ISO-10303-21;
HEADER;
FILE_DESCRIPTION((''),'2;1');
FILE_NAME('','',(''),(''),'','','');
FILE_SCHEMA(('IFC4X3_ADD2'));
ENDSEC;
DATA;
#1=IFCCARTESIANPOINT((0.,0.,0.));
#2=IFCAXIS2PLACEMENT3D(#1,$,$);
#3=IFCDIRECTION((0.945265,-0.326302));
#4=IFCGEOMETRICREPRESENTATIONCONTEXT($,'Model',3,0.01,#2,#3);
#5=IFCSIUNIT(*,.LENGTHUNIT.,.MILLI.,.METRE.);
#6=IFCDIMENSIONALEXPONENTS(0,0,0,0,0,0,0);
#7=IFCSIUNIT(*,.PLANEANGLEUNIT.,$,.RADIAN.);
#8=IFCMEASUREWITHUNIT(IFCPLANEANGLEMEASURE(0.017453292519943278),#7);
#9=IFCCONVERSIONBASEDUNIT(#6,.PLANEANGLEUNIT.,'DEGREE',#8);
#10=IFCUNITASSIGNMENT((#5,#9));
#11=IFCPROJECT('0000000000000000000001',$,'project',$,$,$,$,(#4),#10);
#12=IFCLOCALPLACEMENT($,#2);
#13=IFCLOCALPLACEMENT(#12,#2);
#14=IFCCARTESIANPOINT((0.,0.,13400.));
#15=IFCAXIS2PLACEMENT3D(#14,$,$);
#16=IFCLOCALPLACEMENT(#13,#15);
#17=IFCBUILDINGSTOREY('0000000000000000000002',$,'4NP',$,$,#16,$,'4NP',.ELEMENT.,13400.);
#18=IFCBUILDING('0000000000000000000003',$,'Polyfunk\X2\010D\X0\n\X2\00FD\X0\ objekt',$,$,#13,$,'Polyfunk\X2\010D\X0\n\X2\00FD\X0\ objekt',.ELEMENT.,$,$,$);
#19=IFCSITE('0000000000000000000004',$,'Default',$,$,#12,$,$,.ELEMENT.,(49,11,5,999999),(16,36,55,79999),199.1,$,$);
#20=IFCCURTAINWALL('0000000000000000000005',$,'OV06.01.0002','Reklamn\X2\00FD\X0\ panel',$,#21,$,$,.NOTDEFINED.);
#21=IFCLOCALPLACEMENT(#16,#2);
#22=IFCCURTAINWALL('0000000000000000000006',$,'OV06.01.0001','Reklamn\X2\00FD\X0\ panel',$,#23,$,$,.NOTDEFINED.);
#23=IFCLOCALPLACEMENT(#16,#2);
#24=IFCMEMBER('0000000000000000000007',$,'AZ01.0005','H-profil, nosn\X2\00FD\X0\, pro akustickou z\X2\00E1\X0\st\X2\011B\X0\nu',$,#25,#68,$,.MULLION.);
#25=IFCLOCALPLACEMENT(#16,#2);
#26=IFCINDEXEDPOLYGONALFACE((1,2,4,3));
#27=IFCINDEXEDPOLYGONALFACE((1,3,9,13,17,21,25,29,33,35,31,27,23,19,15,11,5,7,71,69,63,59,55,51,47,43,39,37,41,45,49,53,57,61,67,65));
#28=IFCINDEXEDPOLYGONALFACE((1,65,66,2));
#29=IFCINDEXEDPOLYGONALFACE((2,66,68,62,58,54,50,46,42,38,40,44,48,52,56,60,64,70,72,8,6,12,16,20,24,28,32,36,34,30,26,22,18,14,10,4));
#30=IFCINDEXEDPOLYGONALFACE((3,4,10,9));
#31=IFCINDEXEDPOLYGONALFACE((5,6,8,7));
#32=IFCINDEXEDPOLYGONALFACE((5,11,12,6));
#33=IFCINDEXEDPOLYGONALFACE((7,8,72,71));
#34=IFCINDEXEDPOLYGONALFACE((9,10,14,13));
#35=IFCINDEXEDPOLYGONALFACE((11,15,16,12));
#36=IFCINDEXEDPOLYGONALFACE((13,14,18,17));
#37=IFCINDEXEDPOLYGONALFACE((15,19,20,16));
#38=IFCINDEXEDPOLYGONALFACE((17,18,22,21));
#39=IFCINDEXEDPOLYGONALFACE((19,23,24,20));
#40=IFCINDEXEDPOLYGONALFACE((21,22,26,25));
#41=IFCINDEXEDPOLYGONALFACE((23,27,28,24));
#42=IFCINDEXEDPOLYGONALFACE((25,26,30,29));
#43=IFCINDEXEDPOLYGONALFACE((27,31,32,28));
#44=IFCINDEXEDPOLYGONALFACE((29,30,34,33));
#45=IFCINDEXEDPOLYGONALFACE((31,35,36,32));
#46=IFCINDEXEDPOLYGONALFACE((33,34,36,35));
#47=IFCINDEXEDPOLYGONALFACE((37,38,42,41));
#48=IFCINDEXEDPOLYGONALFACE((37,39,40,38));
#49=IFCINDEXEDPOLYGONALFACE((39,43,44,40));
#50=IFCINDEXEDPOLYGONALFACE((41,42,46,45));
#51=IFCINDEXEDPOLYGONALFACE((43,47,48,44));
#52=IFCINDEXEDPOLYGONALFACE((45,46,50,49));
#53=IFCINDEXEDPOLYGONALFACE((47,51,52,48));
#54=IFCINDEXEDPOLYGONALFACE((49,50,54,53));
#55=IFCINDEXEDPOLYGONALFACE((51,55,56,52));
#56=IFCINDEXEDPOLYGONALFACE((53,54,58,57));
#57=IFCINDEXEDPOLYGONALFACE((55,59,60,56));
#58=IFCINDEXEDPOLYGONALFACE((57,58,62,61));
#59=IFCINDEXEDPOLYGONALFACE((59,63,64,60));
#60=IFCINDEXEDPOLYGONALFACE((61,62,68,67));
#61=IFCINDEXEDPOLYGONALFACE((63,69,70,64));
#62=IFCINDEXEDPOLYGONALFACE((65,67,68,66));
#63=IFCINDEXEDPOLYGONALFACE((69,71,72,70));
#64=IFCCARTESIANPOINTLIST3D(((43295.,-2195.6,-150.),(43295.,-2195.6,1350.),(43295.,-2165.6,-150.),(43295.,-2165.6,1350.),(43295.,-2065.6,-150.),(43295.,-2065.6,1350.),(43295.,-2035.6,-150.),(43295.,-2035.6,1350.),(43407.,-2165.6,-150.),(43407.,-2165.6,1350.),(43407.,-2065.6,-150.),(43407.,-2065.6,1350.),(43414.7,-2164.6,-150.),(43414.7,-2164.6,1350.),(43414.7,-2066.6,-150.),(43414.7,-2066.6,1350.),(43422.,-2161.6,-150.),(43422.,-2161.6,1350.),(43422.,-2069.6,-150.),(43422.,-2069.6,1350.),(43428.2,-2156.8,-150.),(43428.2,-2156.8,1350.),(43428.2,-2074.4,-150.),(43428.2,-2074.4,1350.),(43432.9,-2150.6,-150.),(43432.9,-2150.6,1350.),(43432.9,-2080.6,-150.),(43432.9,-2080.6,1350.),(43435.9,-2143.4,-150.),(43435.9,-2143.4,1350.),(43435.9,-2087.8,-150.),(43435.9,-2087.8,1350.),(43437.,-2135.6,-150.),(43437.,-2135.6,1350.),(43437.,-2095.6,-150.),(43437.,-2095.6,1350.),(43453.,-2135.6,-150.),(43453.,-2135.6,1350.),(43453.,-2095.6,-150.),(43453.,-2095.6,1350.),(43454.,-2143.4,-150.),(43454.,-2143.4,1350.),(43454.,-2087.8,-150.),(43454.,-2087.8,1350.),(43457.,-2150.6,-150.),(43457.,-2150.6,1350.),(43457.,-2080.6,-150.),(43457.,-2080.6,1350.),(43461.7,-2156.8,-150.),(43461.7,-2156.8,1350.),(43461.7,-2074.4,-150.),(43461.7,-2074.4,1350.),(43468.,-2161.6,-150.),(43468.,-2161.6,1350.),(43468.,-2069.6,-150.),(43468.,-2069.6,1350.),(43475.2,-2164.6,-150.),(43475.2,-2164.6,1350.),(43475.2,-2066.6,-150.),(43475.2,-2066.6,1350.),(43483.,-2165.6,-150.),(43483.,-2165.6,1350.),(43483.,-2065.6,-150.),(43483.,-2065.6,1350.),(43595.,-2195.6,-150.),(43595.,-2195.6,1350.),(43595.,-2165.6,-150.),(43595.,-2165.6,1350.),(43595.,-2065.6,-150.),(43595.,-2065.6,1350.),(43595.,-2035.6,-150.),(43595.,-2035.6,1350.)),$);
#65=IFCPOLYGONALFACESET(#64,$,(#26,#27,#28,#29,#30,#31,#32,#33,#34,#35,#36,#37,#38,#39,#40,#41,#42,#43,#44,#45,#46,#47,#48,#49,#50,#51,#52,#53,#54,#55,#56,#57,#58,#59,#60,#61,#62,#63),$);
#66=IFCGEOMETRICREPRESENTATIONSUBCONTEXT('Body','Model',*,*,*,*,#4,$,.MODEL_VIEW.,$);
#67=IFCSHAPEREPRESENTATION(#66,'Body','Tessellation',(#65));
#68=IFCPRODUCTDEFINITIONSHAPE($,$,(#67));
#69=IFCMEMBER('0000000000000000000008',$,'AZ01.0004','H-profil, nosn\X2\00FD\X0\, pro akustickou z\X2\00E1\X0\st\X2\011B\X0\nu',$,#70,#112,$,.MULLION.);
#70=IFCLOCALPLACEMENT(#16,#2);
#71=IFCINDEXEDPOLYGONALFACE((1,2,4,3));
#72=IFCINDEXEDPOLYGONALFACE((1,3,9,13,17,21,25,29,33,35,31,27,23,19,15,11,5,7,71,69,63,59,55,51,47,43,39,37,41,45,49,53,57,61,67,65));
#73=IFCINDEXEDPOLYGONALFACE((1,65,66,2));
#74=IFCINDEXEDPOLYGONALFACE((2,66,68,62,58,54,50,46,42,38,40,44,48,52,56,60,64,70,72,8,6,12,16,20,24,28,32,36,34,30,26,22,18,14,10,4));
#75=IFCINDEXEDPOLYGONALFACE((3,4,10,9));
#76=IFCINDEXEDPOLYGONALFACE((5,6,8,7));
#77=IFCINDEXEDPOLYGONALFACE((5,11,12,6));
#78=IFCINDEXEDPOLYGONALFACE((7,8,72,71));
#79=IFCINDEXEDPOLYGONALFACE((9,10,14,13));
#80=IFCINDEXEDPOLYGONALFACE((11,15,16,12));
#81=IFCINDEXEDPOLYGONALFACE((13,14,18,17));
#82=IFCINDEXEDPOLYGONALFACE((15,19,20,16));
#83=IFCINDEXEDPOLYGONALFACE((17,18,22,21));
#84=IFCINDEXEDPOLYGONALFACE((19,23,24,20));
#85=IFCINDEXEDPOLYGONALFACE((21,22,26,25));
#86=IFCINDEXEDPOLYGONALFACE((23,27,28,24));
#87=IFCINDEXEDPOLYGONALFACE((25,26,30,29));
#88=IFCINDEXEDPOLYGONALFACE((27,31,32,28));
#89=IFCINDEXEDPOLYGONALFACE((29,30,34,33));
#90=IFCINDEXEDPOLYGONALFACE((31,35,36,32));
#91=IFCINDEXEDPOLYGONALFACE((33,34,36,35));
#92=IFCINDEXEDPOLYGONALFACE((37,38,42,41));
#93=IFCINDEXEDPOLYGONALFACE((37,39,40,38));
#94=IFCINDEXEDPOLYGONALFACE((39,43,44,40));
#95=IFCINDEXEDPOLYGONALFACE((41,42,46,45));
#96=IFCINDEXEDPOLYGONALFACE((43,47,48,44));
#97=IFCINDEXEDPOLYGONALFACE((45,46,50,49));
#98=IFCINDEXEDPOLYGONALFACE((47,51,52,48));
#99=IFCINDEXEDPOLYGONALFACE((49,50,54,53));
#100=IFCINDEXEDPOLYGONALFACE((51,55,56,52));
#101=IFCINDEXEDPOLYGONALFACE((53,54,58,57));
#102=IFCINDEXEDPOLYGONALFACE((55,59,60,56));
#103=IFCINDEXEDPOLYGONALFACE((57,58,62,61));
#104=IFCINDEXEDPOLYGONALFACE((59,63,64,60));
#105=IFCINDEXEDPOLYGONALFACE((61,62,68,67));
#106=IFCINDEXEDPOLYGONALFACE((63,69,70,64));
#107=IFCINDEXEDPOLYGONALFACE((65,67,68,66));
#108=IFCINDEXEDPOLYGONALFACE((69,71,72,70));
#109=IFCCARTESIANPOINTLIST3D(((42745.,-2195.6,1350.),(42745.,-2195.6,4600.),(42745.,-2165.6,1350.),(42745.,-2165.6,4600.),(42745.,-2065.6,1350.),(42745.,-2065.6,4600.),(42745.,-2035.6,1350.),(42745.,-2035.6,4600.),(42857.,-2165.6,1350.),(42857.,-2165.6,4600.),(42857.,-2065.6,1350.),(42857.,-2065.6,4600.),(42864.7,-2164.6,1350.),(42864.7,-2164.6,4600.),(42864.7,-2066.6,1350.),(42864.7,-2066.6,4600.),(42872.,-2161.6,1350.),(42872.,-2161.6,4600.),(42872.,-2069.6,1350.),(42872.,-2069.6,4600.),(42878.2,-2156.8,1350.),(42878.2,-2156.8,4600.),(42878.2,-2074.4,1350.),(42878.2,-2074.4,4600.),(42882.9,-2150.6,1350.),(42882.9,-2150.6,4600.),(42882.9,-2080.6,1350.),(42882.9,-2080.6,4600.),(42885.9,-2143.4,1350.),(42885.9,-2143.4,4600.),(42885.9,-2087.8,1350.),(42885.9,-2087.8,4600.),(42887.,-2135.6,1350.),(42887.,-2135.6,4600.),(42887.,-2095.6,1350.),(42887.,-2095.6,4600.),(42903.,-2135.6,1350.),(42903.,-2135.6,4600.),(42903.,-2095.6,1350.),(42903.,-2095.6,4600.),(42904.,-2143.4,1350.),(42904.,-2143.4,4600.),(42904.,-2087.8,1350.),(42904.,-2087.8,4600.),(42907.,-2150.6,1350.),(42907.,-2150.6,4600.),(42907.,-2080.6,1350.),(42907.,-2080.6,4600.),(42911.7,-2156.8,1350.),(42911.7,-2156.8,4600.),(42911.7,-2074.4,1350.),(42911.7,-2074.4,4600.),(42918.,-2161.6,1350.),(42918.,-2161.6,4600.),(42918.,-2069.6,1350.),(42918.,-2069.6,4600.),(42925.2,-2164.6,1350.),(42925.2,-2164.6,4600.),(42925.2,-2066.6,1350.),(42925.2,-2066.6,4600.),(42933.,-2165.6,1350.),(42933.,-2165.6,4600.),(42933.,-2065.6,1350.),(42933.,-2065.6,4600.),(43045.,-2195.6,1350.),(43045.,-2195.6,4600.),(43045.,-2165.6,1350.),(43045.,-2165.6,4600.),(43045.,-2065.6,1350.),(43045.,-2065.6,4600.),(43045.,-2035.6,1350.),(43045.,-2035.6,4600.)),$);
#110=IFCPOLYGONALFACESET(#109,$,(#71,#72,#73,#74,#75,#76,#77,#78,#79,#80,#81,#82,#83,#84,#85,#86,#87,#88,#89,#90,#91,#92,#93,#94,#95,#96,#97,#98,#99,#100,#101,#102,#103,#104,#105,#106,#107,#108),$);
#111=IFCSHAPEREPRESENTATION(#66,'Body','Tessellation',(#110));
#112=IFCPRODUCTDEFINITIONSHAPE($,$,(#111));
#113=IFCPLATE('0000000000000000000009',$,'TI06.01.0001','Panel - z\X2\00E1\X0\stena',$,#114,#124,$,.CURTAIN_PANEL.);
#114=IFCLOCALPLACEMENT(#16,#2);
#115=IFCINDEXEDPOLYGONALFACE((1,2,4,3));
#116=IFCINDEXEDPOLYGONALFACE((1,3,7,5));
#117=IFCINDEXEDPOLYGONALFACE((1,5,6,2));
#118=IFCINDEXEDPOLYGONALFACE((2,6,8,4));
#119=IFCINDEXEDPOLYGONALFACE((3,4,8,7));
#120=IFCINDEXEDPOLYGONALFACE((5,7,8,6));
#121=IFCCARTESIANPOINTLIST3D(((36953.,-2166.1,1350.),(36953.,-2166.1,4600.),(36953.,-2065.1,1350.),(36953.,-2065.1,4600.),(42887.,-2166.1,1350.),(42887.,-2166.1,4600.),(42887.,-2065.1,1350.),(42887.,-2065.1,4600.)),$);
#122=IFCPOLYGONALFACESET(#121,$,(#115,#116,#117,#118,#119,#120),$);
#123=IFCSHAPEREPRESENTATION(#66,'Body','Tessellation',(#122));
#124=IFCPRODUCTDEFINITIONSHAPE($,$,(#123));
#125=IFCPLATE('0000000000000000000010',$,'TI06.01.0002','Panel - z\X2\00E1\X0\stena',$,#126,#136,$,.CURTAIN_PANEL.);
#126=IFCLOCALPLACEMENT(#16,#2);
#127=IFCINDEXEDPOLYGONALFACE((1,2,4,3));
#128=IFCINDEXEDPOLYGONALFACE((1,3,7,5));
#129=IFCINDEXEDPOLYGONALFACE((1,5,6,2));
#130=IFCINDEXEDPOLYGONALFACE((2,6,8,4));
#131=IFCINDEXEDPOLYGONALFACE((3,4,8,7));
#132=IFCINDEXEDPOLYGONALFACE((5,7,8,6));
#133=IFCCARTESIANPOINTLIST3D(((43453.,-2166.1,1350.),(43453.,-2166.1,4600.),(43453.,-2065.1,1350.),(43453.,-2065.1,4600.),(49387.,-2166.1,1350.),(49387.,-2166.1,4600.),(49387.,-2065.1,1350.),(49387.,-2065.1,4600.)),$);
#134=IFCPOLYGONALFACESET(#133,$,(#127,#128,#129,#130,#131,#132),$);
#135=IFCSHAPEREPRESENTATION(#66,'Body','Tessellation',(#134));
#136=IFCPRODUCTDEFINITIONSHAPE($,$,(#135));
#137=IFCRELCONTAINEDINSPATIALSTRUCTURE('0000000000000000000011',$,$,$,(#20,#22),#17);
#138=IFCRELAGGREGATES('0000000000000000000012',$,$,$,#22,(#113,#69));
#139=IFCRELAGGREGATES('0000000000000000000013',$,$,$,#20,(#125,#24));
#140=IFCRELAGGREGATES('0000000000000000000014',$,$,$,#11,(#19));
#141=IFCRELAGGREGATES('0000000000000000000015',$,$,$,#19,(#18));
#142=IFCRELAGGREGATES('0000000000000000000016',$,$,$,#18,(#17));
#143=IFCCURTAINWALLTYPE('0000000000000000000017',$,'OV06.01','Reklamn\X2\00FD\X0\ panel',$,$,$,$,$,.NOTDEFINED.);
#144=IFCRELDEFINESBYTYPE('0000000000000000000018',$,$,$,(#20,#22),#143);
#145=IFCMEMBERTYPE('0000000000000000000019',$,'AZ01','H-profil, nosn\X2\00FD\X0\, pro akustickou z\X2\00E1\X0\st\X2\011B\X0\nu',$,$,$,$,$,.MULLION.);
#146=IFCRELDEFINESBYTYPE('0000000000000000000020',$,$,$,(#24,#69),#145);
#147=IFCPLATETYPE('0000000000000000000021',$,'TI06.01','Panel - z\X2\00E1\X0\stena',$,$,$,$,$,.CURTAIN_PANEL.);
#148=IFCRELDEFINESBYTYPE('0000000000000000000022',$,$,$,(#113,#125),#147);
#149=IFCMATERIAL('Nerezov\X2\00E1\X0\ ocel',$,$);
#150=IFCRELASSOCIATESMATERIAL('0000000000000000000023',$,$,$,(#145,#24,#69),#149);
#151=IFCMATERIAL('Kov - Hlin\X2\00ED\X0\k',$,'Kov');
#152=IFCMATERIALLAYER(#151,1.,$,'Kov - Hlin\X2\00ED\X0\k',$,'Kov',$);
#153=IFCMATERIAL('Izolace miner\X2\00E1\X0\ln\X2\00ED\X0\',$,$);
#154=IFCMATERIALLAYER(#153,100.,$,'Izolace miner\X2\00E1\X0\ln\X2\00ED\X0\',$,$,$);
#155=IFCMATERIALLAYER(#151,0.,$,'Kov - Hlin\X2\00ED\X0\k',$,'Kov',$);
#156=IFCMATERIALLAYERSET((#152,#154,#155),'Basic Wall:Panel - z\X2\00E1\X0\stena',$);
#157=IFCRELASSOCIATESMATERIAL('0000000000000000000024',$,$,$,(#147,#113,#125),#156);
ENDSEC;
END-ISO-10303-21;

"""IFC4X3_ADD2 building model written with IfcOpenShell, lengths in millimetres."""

from ifc_helpers import new_model, entity, si_unit, converted_unit, direction, frame, frame_2d, origin, place, context, subcontext, project, spatial, polyline, circle_curve, parameter, trimmed, segment, composite_curve, rectangle, outline, extrude, source, transform, mapped, material, layer, layer_set, layer_usage, material_profile, profile_set, profile_usage, type_object, element, aggregate, save


model = new_model("IFC4X3_ADD2")

# Units and contexts
model_context = context("Model", 3, precision=0.01, world=origin(), true_north=direction((0.945265, -0.326302)))
body_context = subcontext(model_context, "Body", "Model", "MODEL_VIEW")
ifc_project = project(units=[si_unit("LENGTHUNIT", "METRE", prefix="MILLI"), converted_unit("PLANEANGLEUNIT", "DEGREE", entity("IfcPlaneAngleMeasure", 0.017453292519943278), si_unit("PLANEANGLEUNIT", "RADIAN"), dimensions=[0, 0, 0, 0, 0, 0, 0])], contexts=[model_context])

# Site, building, storey
site_placement = place(None, origin())
site = spatial("IfcSite", under=ifc_project, at=site_placement, Name="Default", CompositionType="ELEMENT", RefLatitude=(49, 11, 5, 999999), RefLongitude=(16, 36, 55, 79999), RefElevation=199.1)
building_placement = place(site_placement, origin())
building = spatial("IfcBuilding", under=site, at=building_placement, Name="Polyfunkčný objekt", LongName="Polyfunkčný objekt", CompositionType="ELEMENT")
storey_placement = place(building_placement, frame((0.0, 0.0, 13400.0)))
storey = spatial("IfcBuildingStorey", under=building, at=storey_placement, Name="4NP", LongName="4NP", CompositionType="ELEMENT", Elevation=13400.0)

# Curtain walls
curtain_wall_type = type_object("IfcCurtainWallType", Name="OV06.01", Description="Reklamný panel", PredefinedType="NOTDEFINED")
curtain_wall_1_placement = place(storey_placement, frame((0.0, 0.0, -13400.0)))
curtain_wall_1 = element("IfcCurtainWall", 1, at=curtain_wall_1_placement, inside=storey, type_object=curtain_wall_type, Name="OV06.01.0002", Description="Reklamný panel", PredefinedType="NOTDEFINED")
ifc_material_1 = material(Name="Nerezová ocel")
ifc_material_profile = material_profile(ifc_material_1, outline(composite_curve([segment(polyline([(50.0, -150.0), (80.0, -150.0)]), True, "CONTINUOUS"), segment(polyline([(80.0, -150.0), (80.0, 150.0)]), True, "CONTINUOUS"), segment(polyline([(80.0, 150.0), (50.0, 150.0)]), True, "CONTINUOUS"), segment(polyline([(50.0, 150.0), (50.0, 38.0)]), True, "CONTINUOUS"), segment(trimmed(circle_curve(frame_2d((20.0, 38.0), x_axis=(0.0, 1.0)), 30.0), [parameter(180.0)], [parameter(270.0)], True, "PARAMETER"), False, "CONTINUOUS"), segment(polyline([(20.0, 8.0), (-20.0, 8.0)]), True, "CONTINUOUS"), segment(trimmed(circle_curve(frame_2d((-20.0, 38.0), x_axis=(0.0, 1.0)), 30.0), [parameter(90.0)], [parameter(180.0)], True, "PARAMETER"), False, "CONTINUOUS"), segment(polyline([(-50.0, 38.0), (-50.0, 150.0)]), True, "CONTINUOUS"), segment(polyline([(-50.0, 150.0), (-80.0, 150.0)]), True, "CONTINUOUS"), segment(polyline([(-80.0, 150.0), (-80.0, -150.0)]), True, "CONTINUOUS"), segment(polyline([(-80.0, -150.0), (-50.0, -150.0)]), True, "CONTINUOUS"), segment(polyline([(-50.0, -150.0), (-50.0, -38.0)]), True, "CONTINUOUS"), segment(trimmed(circle_curve(frame_2d((-20.0, -38.0), x_axis=(0.0, 1.0)), 30.0), [parameter(0.0)], [parameter(90.0)], True, "PARAMETER"), False, "CONTINUOUS"), segment(polyline([(-20.0, -8.0), (20.0, -8.0)]), True, "CONTINUOUS"), segment(trimmed(circle_curve(frame_2d((20.0, -38.0), x_axis=(0.0, 1.0)), 30.0), [parameter(270.0)], [parameter(0.0)], True, "PARAMETER"), False, "CONTINUOUS"), segment(polyline([(50.0, -38.0), (50.0, -150.0)]), True, "CONTINUOUS")], self_intersect=False)), Name="Profil zástena")
ifc_profile_set = profile_set([ifc_material_profile], Name="Profil zástena")
ifc_profile_usage = profile_usage(ifc_profile_set)
member_type_1 = type_object("IfcMemberType", Name="AZ01", Description="H-profil, nosný, pro akustickou zástěnu", PredefinedType="MULLION", material=ifc_profile_set)
curtain_wall_2_placement = place(storey_placement, frame((0.0, 0.0, -13400.0)))
curtain_wall_2 = element("IfcCurtainWall", 2, at=curtain_wall_2_placement, inside=storey, type_object=curtain_wall_type, Name="OV06.01.0001", Description="Reklamný panel", PredefinedType="NOTDEFINED")

# Members
shared_shape_1 = source(origin(), body_context, "Body", "SweptSolid", [
    extrude(outline(composite_curve([segment(polyline([(50.0, -150.0), (80.0, -150.0)]), True, "CONTINUOUS"), segment(polyline([(80.0, -150.0), (80.0, 150.0)]), True, "CONTINUOUS"), segment(polyline([(80.0, 150.0), (50.0, 150.0)]), True, "CONTINUOUS"), segment(polyline([(50.0, 150.0), (50.0, 38.0)]), True, "CONTINUOUS"), segment(trimmed(circle_curve(frame_2d((20.0, 38.0), x_axis=(0.0, 1.0)), 30.0), [parameter(180.0)], [parameter(270.0)], True, "PARAMETER"), False, "CONTINUOUS"), segment(polyline([(20.0, 8.0), (-20.0, 8.0)]), True, "CONTINUOUS"), segment(trimmed(circle_curve(frame_2d((-20.0, 38.0), x_axis=(0.0, 1.0)), 30.0), [parameter(90.0)], [parameter(180.0)], True, "PARAMETER"), False, "CONTINUOUS"), segment(polyline([(-50.0, 38.0), (-50.0, 150.0)]), True, "CONTINUOUS"), segment(polyline([(-50.0, 150.0), (-80.0, 150.0)]), True, "CONTINUOUS"), segment(polyline([(-80.0, 150.0), (-80.0, -150.0)]), True, "CONTINUOUS"), segment(polyline([(-80.0, -150.0), (-50.0, -150.0)]), True, "CONTINUOUS"), segment(polyline([(-50.0, -150.0), (-50.0, -38.0)]), True, "CONTINUOUS"), segment(trimmed(circle_curve(frame_2d((-20.0, -38.0), x_axis=(0.0, 1.0)), 30.0), [parameter(0.0)], [parameter(90.0)], True, "PARAMETER"), False, "CONTINUOUS"), segment(polyline([(-20.0, -8.0), (20.0, -8.0)]), True, "CONTINUOUS"), segment(trimmed(circle_curve(frame_2d((20.0, -38.0), x_axis=(0.0, 1.0)), 30.0), [parameter(270.0)], [parameter(0.0)], True, "PARAMETER"), False, "CONTINUOUS"), segment(polyline([(50.0, -38.0), (50.0, -150.0)]), True, "CONTINUOUS")], self_intersect=False)), frame((-150.0, 0.0, -1500.0), z_axis=(0.0, 0.0, 1.0), x_axis=(0.0, 1.0, 0.0)), (0.0, 0.0, 1.0), 1500.0),
])
member_1_placement = place(curtain_wall_1_placement, frame((43295.0, -2115.6, 14750.0), z_axis=(0.0, 0.0, 1.0), x_axis=(-1.0, 0.0, 0.0)))
member_1 = element("IfcMember", 3, at=member_1_placement, type_object=member_type_1, material=ifc_profile_usage, Name="AZ01.0005", Description="H-profil, nosný, pro akustickou zástěnu", PredefinedType="MULLION", context=body_context, shape_type="MappedRepresentation", body=[
    mapped(shared_shape_1, transform((0.0, 0.0, 0.0), scale=1.0)),
])
shared_shape_2 = source(origin(), body_context, "Body", "SweptSolid", [
    extrude(outline(composite_curve([segment(polyline([(-150.0, -50.0), (-150.0, -80.0)]), True, "CONTINUOUS"), segment(polyline([(-150.0, -80.0), (150.0, -80.0)]), True, "CONTINUOUS"), segment(polyline([(150.0, -80.0), (150.0, -50.0)]), True, "CONTINUOUS"), segment(polyline([(150.0, -50.0), (38.0, -50.0)]), True, "CONTINUOUS"), segment(trimmed(circle_curve(frame_2d((38.0, -20.0), x_axis=(1.0, 0.0)), 30.0), [parameter(180.0)], [parameter(270.0)], True, "PARAMETER"), False, "CONTINUOUS"), segment(polyline([(8.0, -20.0), (8.0, 20.0)]), True, "CONTINUOUS"), segment(trimmed(circle_curve(frame_2d((38.0, 20.0), x_axis=(1.0, 0.0)), 30.0), [parameter(90.0)], [parameter(180.0)], True, "PARAMETER"), False, "CONTINUOUS"), segment(polyline([(38.0, 50.0), (150.0, 50.0)]), True, "CONTINUOUS"), segment(polyline([(150.0, 50.0), (150.0, 80.0)]), True, "CONTINUOUS"), segment(polyline([(150.0, 80.0), (-150.0, 80.0)]), True, "CONTINUOUS"), segment(polyline([(-150.0, 80.0), (-150.0, 50.0)]), True, "CONTINUOUS"), segment(polyline([(-150.0, 50.0), (-38.0, 50.0)]), True, "CONTINUOUS"), segment(trimmed(circle_curve(frame_2d((-38.0, 20.0), x_axis=(1.0, 0.0)), 30.0), [parameter(0.0)], [parameter(90.0)], True, "PARAMETER"), False, "CONTINUOUS"), segment(polyline([(-8.0, 20.0), (-8.0, -20.0)]), True, "CONTINUOUS"), segment(trimmed(circle_curve(frame_2d((-38.0, -20.0), x_axis=(1.0, 0.0)), 30.0), [parameter(270.0)], [parameter(0.0)], True, "PARAMETER"), False, "CONTINUOUS"), segment(polyline([(-38.0, -50.0), (-150.0, -50.0)]), True, "CONTINUOUS")], self_intersect=False)), frame((-150.0, 0.0, -3250.0), z_axis=(0.0, 0.0, -1.0), x_axis=(1.0, 0.0, 0.0)), (0.0, 0.0, -1.0), 3250.0),
])
member_2_placement = place(curtain_wall_2_placement, frame((43045.0, -2115.6, 14750.0), z_axis=(0.0, 0.0, -1.0), x_axis=(1.0, 0.0, 0.0)))
member_2 = element("IfcMember", 4, at=member_2_placement, type_object=member_type_1, material=ifc_profile_usage, Name="AZ01.0004", Description="H-profil, nosný, pro akustickou zástěnu", PredefinedType="MULLION", context=body_context, shape_type="MappedRepresentation", body=[
    mapped(shared_shape_2, transform((0.0, 0.0, 0.0), scale=1.0)),
])

# Plates
ifc_material_2 = material(Name="Kov - Hliník", Category="Kov")
ifc_layer_1 = layer(ifc_material_2, 1.0, Name="Kov - Hliník", Category="Kov")
ifc_material_3 = material(Name="Izolace minerální")
ifc_layer_2 = layer(ifc_material_3, 100.0, Name="Izolace minerální")
ifc_layer_3 = layer(ifc_material_2, 0.0, Name="Kov - Hliník", Category="Kov")
ifc_layer_set_1 = layer_set([ifc_layer_1, ifc_layer_2, ifc_layer_3], Name="Basic Wall:Panel - zástena")
ifc_layer_usage_1 = layer_usage(ifc_layer_set_1, "AXIS2", "NEGATIVE", 50.5)
plate_type = type_object("IfcPlateType", Name="TI06.01", Description="Panel - zástena", PredefinedType="CURTAIN_PANEL", material=ifc_layer_set_1)
plate_1_placement = place(storey_placement, frame((36953.0, -2115.6, 1350.0)))
plate_1 = element("IfcPlate", 5, at=plate_1_placement, type_object=plate_type, material=ifc_layer_usage_1, Name="TI06.01.0001", Description="Panel - zástena", PredefinedType="CURTAIN_PANEL", context=body_context, shape_type="SweptSolid", body=[
    extrude(rectangle(XDim=101.0, YDim=5934.0, at=frame_2d((0.0, 0.0), x_axis=(1.0, 0.0))), frame((2967.0, 0.0, 0.0), z_axis=(0.0, 0.0, 1.0), x_axis=(0.0, 1.0, 0.0)), (0.0, 0.0, 1.0), 3250.0),
])
aggregate(curtain_wall_2, [plate_1, member_2])
ifc_layer_usage_2 = layer_usage(ifc_layer_set_1, "AXIS2", "NEGATIVE", 50.5)
plate_2_placement = place(storey_placement, frame((43453.0, -2115.6, 1350.0)))
plate_2 = element("IfcPlate", 6, at=plate_2_placement, type_object=plate_type, material=ifc_layer_usage_2, Name="TI06.01.0002", Description="Panel - zástena", PredefinedType="CURTAIN_PANEL", context=body_context, shape_type="SweptSolid", body=[
    extrude(rectangle(XDim=101.0, YDim=5934.0, at=frame_2d((0.0, 0.0), x_axis=(1.0, 0.0))), frame((2967.0, 0.0, 0.0), z_axis=(0.0, 0.0, 1.0), x_axis=(0.0, 1.0, 0.0)), (0.0, 0.0, 1.0), 3250.0),
])
aggregate(curtain_wall_1, [plate_2, member_1])

save(model, "model.ifc")
